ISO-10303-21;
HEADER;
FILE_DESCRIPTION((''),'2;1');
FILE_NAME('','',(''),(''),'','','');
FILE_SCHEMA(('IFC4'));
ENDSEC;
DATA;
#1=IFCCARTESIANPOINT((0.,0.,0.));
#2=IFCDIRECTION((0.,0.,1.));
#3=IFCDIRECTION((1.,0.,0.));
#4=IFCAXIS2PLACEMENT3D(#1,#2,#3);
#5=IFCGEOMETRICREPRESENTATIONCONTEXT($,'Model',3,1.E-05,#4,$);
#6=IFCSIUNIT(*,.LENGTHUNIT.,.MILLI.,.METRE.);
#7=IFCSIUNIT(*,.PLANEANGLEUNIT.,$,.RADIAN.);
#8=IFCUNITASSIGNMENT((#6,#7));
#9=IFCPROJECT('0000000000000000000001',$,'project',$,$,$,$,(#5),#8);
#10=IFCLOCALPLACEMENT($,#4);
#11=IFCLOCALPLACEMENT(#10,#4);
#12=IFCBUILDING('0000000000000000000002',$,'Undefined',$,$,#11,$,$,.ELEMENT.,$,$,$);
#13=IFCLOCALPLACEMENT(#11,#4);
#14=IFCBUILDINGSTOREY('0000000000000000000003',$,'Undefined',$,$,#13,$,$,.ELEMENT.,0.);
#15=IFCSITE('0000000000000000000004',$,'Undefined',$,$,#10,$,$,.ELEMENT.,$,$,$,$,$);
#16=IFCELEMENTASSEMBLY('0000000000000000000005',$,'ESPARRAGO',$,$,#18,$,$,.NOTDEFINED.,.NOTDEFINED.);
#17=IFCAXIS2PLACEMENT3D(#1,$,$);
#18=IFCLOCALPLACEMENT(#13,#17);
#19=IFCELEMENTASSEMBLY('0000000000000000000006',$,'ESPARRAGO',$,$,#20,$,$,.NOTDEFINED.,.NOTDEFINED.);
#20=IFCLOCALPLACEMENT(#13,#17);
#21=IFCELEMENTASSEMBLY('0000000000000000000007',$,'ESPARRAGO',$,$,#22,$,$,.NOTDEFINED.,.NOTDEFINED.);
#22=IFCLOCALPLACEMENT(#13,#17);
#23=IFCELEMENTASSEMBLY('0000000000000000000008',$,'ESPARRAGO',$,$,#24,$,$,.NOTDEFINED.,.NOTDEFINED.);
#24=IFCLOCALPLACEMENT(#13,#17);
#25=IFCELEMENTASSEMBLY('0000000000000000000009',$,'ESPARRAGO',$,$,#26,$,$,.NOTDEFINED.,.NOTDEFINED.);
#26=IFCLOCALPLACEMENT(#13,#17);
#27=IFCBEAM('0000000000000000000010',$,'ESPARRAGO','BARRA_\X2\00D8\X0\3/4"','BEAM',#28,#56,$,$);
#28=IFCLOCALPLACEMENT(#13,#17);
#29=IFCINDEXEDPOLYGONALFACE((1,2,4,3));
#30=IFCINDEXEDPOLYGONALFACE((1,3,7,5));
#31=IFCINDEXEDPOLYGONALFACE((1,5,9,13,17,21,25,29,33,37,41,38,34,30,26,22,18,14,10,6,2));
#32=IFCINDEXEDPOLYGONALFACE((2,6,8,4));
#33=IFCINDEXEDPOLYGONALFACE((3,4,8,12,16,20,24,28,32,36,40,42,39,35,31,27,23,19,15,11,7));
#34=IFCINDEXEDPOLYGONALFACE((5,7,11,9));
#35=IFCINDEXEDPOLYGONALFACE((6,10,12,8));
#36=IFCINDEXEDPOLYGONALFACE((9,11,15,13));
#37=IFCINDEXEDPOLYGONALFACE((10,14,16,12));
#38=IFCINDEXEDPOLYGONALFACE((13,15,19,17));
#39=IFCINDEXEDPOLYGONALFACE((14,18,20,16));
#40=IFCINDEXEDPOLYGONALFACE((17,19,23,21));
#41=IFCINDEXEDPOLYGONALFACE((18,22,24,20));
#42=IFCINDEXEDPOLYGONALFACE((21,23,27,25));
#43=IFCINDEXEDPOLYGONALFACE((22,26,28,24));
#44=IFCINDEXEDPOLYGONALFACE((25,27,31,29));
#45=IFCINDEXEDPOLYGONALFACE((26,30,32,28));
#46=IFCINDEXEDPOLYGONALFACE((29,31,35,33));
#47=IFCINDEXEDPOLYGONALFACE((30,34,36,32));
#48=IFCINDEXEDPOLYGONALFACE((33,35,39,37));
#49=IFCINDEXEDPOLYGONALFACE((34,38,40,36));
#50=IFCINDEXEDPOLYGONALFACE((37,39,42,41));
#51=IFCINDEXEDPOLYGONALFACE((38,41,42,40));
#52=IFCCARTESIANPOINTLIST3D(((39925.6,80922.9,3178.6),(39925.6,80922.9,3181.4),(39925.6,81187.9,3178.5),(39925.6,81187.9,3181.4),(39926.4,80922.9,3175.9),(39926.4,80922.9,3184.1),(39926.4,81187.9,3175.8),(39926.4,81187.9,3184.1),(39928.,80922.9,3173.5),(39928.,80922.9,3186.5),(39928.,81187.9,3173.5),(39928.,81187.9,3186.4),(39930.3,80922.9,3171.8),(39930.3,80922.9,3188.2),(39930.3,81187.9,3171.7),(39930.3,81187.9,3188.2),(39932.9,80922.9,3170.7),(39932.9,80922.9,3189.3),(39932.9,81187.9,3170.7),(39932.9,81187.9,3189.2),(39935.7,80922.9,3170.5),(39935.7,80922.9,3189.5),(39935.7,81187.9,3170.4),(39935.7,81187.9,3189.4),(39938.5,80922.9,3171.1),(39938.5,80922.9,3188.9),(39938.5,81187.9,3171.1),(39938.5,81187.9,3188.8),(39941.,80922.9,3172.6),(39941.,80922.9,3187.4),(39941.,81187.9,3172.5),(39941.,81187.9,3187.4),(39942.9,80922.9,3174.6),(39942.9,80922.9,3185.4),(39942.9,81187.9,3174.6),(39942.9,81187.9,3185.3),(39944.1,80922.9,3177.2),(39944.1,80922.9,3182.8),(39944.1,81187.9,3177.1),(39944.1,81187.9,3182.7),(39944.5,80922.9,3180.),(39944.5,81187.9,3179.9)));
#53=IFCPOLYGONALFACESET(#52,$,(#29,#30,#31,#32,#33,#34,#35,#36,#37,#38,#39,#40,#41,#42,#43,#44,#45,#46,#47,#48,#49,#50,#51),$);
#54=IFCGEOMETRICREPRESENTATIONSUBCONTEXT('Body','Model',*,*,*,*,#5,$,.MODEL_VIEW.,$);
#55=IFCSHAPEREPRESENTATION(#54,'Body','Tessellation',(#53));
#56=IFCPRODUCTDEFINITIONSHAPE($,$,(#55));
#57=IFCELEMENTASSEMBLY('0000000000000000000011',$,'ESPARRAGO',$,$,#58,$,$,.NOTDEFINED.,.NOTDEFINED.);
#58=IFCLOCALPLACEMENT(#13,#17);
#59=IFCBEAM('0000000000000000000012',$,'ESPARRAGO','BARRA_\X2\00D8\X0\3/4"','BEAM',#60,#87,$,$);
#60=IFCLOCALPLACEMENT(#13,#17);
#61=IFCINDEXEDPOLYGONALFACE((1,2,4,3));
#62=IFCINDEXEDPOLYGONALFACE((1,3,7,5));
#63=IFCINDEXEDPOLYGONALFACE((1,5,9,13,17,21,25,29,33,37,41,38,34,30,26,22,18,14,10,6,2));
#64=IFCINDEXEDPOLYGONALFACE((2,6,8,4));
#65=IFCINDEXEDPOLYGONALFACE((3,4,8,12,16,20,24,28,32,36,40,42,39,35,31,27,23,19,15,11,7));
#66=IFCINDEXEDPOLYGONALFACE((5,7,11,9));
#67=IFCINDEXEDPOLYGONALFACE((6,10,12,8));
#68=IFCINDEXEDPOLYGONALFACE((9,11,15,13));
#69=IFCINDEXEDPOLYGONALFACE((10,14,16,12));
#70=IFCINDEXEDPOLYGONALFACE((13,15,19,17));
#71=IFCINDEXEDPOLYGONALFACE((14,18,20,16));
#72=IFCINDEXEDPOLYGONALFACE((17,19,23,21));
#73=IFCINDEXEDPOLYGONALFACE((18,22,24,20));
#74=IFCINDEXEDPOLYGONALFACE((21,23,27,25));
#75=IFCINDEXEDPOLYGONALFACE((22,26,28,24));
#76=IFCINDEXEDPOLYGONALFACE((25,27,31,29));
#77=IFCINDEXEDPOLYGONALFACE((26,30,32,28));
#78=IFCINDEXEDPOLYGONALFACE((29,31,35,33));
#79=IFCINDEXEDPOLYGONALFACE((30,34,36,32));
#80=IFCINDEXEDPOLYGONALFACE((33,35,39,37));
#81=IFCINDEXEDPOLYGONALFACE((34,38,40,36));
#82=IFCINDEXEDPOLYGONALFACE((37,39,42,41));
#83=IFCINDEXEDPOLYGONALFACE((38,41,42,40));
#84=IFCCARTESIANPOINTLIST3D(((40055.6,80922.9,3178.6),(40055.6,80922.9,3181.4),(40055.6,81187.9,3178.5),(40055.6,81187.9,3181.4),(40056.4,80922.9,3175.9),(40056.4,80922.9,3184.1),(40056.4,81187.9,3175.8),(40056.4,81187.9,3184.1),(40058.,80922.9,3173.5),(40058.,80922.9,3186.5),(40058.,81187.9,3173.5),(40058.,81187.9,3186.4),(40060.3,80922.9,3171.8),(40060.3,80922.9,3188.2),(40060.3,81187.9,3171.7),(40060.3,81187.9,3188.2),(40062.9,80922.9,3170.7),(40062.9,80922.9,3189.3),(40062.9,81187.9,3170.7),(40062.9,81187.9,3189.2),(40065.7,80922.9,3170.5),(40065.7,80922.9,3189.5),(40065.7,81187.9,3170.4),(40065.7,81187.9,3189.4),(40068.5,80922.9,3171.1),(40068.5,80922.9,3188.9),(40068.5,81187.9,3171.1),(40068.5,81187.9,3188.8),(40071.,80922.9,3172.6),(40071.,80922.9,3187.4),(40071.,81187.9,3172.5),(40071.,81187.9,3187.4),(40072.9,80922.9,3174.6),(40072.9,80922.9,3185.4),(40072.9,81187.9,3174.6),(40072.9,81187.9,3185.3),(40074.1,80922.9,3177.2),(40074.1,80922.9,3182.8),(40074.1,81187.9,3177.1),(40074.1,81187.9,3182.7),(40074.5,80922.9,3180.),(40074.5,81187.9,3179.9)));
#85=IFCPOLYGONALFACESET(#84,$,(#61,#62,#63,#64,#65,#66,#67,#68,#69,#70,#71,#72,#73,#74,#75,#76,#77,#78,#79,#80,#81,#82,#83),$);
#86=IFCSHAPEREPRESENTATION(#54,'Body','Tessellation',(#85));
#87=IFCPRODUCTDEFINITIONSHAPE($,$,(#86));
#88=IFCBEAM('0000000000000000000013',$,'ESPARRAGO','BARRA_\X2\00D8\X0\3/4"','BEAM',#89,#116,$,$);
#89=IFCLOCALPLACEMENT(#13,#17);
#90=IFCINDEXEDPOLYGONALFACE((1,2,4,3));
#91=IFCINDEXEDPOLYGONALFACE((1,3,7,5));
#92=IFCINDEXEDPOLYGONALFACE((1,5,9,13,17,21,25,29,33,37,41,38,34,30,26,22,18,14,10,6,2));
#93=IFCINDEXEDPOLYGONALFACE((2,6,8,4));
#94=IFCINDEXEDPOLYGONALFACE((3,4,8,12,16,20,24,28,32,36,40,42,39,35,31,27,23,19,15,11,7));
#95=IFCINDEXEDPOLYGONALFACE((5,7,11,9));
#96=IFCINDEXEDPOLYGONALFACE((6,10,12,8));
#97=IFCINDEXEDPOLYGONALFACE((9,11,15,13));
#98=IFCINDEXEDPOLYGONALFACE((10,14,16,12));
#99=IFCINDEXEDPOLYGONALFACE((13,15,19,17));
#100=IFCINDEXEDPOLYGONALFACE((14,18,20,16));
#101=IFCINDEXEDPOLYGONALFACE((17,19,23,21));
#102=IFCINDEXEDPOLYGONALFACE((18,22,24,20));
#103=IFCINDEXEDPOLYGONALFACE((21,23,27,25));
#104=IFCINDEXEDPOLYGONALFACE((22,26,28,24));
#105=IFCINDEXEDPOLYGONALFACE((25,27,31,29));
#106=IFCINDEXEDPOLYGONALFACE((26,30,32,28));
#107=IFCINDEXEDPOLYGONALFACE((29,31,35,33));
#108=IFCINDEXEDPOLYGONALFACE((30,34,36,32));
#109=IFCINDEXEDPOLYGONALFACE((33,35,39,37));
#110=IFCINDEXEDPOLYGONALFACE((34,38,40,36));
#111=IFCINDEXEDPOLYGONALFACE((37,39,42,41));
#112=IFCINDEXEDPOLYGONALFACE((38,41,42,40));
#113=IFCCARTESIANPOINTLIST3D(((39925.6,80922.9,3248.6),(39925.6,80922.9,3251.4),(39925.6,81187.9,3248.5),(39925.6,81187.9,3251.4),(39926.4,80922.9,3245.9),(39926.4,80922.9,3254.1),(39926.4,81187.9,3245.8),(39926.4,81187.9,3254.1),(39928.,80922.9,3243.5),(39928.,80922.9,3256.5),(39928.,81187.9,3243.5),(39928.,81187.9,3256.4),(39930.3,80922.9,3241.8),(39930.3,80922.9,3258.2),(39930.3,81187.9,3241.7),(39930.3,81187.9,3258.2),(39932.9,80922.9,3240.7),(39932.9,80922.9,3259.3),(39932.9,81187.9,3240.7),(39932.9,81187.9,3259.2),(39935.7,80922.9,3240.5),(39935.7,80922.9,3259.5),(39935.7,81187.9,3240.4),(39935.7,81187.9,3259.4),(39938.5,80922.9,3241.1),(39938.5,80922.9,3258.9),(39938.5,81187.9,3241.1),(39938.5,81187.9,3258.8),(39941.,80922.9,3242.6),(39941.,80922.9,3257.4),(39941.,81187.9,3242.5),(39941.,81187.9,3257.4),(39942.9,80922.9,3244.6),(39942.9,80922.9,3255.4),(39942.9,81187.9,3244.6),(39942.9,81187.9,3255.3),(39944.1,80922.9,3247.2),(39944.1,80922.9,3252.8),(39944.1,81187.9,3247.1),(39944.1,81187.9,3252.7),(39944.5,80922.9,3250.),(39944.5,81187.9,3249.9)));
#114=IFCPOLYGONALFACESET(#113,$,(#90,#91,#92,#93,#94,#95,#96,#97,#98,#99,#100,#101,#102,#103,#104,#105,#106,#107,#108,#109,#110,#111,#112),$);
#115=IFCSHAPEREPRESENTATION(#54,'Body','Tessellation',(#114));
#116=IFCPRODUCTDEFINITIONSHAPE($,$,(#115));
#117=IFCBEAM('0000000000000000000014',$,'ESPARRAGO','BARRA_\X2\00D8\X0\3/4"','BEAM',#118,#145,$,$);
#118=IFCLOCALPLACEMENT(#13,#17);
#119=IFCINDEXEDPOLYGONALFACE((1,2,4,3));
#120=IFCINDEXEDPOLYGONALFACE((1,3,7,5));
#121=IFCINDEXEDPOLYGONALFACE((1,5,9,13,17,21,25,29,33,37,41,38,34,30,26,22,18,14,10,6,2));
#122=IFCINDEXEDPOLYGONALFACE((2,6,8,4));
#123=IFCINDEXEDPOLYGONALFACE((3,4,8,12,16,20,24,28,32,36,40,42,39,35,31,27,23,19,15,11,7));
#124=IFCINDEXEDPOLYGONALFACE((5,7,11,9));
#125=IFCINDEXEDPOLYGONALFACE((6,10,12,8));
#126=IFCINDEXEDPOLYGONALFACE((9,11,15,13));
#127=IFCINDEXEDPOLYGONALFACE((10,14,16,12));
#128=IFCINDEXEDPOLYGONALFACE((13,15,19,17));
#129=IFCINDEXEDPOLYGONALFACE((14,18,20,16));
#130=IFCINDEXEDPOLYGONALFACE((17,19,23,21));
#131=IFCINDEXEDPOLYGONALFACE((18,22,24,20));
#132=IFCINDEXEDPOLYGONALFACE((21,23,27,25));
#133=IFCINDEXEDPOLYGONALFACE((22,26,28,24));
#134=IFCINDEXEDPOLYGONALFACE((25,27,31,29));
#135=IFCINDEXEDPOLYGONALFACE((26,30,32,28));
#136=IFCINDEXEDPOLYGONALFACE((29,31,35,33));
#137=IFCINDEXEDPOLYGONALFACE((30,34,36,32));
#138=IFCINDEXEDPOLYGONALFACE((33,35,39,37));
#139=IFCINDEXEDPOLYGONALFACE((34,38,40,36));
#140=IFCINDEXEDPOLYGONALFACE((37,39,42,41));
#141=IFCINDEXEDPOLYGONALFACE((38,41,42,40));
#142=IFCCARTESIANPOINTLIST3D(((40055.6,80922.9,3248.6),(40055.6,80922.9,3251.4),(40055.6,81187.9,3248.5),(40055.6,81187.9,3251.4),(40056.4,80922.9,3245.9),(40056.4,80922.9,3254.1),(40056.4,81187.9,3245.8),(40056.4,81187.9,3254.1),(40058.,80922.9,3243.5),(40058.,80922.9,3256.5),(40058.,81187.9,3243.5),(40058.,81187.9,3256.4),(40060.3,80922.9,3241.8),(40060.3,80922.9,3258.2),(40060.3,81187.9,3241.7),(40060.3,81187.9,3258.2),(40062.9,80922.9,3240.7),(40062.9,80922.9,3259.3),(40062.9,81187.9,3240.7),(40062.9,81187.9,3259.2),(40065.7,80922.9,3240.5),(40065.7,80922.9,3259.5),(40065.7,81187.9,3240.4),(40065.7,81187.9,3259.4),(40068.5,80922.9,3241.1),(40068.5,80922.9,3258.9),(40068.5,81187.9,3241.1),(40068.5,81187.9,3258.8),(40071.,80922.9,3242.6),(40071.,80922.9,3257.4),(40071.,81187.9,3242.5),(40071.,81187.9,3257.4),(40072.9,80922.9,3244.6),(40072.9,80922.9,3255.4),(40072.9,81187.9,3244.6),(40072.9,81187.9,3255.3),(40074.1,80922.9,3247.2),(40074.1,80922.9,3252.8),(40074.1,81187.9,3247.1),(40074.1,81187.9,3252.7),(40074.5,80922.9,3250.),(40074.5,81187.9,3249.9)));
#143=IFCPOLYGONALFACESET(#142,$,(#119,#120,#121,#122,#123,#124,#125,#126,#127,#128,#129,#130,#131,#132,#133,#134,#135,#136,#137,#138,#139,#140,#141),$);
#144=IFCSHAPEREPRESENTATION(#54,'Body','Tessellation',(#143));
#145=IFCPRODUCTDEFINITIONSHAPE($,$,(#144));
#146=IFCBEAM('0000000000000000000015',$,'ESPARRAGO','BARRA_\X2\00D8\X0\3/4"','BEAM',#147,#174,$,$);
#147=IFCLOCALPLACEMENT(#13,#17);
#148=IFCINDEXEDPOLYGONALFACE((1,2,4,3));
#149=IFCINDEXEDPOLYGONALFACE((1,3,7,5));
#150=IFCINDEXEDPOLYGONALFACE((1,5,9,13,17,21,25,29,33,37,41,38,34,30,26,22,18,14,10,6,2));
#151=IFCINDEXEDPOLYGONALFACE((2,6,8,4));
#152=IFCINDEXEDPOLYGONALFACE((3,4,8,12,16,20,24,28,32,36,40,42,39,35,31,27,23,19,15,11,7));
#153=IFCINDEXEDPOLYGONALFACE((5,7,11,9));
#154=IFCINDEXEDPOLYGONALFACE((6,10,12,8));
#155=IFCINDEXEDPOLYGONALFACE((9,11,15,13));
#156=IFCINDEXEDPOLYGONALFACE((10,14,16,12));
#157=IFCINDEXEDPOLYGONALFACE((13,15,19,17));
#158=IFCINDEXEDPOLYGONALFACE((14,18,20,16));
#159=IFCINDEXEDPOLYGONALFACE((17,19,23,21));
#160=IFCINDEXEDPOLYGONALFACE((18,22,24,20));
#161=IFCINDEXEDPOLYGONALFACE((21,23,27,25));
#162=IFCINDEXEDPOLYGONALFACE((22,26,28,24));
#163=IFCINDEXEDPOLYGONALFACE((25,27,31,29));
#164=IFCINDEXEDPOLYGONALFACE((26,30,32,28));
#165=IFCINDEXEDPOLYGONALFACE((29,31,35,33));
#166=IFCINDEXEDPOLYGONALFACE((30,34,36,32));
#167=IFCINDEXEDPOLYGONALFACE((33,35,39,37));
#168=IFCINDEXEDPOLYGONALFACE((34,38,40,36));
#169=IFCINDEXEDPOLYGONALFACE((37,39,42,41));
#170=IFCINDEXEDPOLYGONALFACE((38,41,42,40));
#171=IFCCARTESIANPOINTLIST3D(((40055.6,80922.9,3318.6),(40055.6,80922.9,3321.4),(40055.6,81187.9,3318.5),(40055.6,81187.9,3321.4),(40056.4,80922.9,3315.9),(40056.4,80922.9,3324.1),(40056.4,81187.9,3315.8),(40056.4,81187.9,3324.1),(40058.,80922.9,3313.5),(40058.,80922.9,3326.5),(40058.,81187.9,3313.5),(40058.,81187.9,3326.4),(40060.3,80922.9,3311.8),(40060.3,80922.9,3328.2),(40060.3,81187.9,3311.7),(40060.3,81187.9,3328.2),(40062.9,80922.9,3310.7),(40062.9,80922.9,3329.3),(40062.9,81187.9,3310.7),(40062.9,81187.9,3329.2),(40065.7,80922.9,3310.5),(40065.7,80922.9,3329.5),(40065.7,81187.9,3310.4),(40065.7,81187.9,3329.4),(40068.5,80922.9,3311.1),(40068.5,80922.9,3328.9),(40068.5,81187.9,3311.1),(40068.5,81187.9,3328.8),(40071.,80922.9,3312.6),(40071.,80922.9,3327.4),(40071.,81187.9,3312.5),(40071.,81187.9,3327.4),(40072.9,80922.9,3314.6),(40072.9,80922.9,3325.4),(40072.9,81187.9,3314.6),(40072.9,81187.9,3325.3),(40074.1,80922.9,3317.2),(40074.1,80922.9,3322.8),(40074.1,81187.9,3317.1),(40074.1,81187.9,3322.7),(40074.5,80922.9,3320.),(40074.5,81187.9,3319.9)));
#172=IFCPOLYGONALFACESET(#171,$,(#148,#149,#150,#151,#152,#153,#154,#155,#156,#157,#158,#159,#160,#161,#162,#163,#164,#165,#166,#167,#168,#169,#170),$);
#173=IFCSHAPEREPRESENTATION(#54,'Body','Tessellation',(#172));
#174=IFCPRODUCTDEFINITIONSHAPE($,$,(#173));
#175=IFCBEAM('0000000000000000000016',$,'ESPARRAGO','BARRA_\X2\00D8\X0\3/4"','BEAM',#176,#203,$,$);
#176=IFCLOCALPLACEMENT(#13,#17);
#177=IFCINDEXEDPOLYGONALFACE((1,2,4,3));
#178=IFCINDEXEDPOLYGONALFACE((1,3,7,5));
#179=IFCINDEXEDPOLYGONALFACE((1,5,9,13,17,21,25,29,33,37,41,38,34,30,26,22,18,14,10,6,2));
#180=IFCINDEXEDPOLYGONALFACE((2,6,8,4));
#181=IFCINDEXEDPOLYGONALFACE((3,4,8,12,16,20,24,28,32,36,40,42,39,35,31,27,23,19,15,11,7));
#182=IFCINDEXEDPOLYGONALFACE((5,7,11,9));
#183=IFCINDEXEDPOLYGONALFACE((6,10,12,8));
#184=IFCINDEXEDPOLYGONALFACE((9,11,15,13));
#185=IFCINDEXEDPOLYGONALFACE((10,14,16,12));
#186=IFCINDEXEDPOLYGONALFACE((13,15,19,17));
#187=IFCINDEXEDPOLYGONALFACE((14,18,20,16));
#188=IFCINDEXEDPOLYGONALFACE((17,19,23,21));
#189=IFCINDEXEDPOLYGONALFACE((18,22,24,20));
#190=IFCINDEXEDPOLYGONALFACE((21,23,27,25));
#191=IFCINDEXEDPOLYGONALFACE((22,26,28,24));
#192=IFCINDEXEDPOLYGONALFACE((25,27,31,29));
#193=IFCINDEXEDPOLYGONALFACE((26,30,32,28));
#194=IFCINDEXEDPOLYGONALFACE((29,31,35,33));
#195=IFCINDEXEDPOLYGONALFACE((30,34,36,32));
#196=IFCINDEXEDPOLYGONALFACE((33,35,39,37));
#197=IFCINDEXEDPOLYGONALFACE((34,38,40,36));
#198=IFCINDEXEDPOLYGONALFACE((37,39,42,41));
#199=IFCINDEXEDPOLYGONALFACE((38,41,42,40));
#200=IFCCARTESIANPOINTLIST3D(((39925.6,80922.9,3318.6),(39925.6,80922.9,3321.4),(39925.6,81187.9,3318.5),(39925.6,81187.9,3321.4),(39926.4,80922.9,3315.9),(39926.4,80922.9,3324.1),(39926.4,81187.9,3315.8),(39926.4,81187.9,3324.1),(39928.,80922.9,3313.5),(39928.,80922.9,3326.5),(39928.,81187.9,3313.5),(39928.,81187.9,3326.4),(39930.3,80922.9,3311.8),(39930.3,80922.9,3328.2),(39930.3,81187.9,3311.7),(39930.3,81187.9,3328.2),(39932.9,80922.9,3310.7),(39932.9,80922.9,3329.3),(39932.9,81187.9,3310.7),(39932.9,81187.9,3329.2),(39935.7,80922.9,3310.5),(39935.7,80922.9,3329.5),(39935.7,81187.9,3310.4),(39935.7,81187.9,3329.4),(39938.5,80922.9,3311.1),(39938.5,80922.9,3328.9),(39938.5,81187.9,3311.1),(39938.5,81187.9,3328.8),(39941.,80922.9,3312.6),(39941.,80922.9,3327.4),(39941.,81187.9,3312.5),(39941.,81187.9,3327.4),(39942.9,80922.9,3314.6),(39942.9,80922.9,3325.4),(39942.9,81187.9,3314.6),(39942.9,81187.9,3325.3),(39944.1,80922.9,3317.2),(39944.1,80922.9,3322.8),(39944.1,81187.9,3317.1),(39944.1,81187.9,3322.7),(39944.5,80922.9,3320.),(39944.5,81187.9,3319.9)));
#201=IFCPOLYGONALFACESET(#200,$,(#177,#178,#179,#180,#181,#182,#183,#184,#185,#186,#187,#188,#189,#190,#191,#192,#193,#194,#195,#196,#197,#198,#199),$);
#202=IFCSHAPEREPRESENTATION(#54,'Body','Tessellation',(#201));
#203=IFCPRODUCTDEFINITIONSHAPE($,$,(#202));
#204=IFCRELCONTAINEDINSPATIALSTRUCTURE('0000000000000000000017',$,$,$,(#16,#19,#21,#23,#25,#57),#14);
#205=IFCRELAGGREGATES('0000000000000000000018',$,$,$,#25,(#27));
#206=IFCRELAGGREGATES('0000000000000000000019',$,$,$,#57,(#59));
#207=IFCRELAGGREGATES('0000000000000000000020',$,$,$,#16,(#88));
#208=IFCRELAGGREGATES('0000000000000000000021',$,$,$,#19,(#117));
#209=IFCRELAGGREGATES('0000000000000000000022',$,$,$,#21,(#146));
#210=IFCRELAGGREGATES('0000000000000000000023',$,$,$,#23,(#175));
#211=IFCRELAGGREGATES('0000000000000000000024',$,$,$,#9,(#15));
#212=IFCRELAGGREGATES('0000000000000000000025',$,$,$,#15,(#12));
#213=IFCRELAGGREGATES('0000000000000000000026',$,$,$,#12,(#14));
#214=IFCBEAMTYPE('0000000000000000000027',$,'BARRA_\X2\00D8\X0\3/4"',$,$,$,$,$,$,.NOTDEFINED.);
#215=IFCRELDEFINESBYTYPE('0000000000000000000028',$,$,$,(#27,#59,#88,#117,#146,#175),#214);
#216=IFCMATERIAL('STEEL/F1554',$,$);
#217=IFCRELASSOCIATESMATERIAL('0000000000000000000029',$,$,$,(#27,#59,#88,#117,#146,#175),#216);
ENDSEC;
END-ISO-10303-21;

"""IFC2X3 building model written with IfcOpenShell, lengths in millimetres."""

from ifc_helpers import new_model, si_unit, frame, origin_with_axes, origin_2d_with_axis, place, context, subcontext, project, spatial, circle, extrude, material, type_object, element, aggregate, save


model = new_model("IFC2X3")

# Units and contexts
model_context = context("Model", 3, precision=1e-05, world=origin_with_axes())
body_context = subcontext(model_context, "Body", "Model", "MODEL_VIEW")
ifc_project = project(units=[si_unit("LENGTHUNIT", "METRE", prefix="MILLI"), si_unit("PLANEANGLEUNIT", "RADIAN")], contexts=[model_context])

# Site, building, storey
site_placement = place(None, origin_with_axes())
site = spatial("IfcSite", under=ifc_project, at=site_placement, Name="Undefined", CompositionType="ELEMENT")
building_placement = place(site_placement, origin_with_axes())
building = spatial("IfcBuilding", under=site, at=building_placement, Name="Undefined", CompositionType="ELEMENT")
storey_placement = place(building_placement, origin_with_axes())
storey = spatial("IfcBuildingStorey", under=building, at=storey_placement, Name="Undefined", CompositionType="ELEMENT", Elevation=0.0)

# Element assemblies
assembly_1_placement = place(storey_placement, origin_with_axes())
assembly_1 = element("IfcElementAssembly", 1, at=assembly_1_placement, inside=storey, Name="ESPARRAGO", AssemblyPlace="NOTDEFINED", PredefinedType="NOTDEFINED")
assembly_2_placement = place(storey_placement, origin_with_axes())
assembly_2 = element("IfcElementAssembly", 2, at=assembly_2_placement, inside=storey, Name="ESPARRAGO", AssemblyPlace="NOTDEFINED", PredefinedType="NOTDEFINED")
assembly_3_placement = place(storey_placement, origin_with_axes())
assembly_3 = element("IfcElementAssembly", 3, at=assembly_3_placement, inside=storey, Name="ESPARRAGO", AssemblyPlace="NOTDEFINED", PredefinedType="NOTDEFINED")
assembly_4_placement = place(storey_placement, origin_with_axes())
assembly_4 = element("IfcElementAssembly", 4, at=assembly_4_placement, inside=storey, Name="ESPARRAGO", AssemblyPlace="NOTDEFINED", PredefinedType="NOTDEFINED")

# Element assemblies, beams
assembly_5_placement = place(storey_placement, origin_with_axes())
assembly_5 = element("IfcElementAssembly", 5, at=assembly_5_placement, inside=storey, Name="ESPARRAGO", AssemblyPlace="NOTDEFINED", PredefinedType="NOTDEFINED")
ifc_material_1 = material(Name="STEEL/F1554")
beam_type_1 = type_object("IfcBeamType", Name="BARRA_Ø3/4\"", PredefinedType="NOTDEFINED")
beam_1_placement = place(assembly_5_placement, frame((39935.0, 80922.9, 3180.0), z_axis=(0.0, 0.000238, 1.0), x_axis=(0.000019, 1.0, -0.000238)))
beam_1 = element("IfcBeam", 6, at=beam_1_placement, type_object=beam_type_1, material=ifc_material_1, Name="ESPARRAGO", Description="BARRA_Ø3/4\"", ObjectType="BEAM", context=body_context, shape_type="SweptSolid", body=[
    extrude(circle(Radius=9.5, at=origin_2d_with_axis()), frame((265.0, 0.0, 0.0), z_axis=(-1.0, 0.0, 0.0), x_axis=(0.0, -1.0, 0.0)), (0.0, 0.0, 1.0), 265.0),
])
aggregate(assembly_5, [beam_1])
assembly_6_placement = place(storey_placement, origin_with_axes())
assembly_6 = element("IfcElementAssembly", 7, at=assembly_6_placement, inside=storey, Name="ESPARRAGO", AssemblyPlace="NOTDEFINED", PredefinedType="NOTDEFINED")
beam_2_placement = place(assembly_6_placement, frame((40065.0, 80922.9, 3180.0), z_axis=(0.0, 0.000238, 1.0), x_axis=(0.000019, 1.0, -0.000238)))
beam_2 = element("IfcBeam", 8, at=beam_2_placement, type_object=beam_type_1, material=ifc_material_1, Name="ESPARRAGO", Description="BARRA_Ø3/4\"", ObjectType="BEAM", context=body_context, shape_type="SweptSolid", body=[
    extrude(circle(Radius=9.5, at=origin_2d_with_axis()), frame((265.0, 0.0, 0.0), z_axis=(-1.0, 0.0, 0.0), x_axis=(0.0, -1.0, 0.0)), (0.0, 0.0, 1.0), 265.0),
])
aggregate(assembly_6, [beam_2])

# Beams
beam_3_placement = place(assembly_1_placement, frame((39935.0, 80922.9, 3250.0), z_axis=(0.0, 0.000238, 1.0), x_axis=(0.000019, 1.0, -0.000238)))
beam_3 = element("IfcBeam", 9, at=beam_3_placement, type_object=beam_type_1, material=ifc_material_1, Name="ESPARRAGO", Description="BARRA_Ø3/4\"", ObjectType="BEAM", context=body_context, shape_type="SweptSolid", body=[
    extrude(circle(Radius=9.5, at=origin_2d_with_axis()), frame((265.0, 0.0, 0.0), z_axis=(-1.0, 0.0, 0.0), x_axis=(0.0, -1.0, 0.0)), (0.0, 0.0, 1.0), 265.0),
])
aggregate(assembly_1, [beam_3])
beam_4_placement = place(assembly_2_placement, frame((40065.0, 80922.9, 3250.0), z_axis=(0.0, 0.000238, 1.0), x_axis=(0.000019, 1.0, -0.000238)))
beam_4 = element("IfcBeam", 10, at=beam_4_placement, type_object=beam_type_1, material=ifc_material_1, Name="ESPARRAGO", Description="BARRA_Ø3/4\"", ObjectType="BEAM", context=body_context, shape_type="SweptSolid", body=[
    extrude(circle(Radius=9.5, at=origin_2d_with_axis()), frame((265.0, 0.0, 0.0), z_axis=(-1.0, 0.0, 0.0), x_axis=(0.0, -1.0, 0.0)), (0.0, 0.0, 1.0), 265.0),
])
aggregate(assembly_2, [beam_4])
beam_5_placement = place(assembly_3_placement, frame((40065.0, 80922.9, 3320.0), z_axis=(0.0, 0.000238, 1.0), x_axis=(0.000019, 1.0, -0.000238)))
beam_5 = element("IfcBeam", 11, at=beam_5_placement, type_object=beam_type_1, material=ifc_material_1, Name="ESPARRAGO", Description="BARRA_Ø3/4\"", ObjectType="BEAM", context=body_context, shape_type="SweptSolid", body=[
    extrude(circle(Radius=9.5, at=origin_2d_with_axis()), frame((265.0, 0.0, 0.0), z_axis=(-1.0, 0.0, 0.0), x_axis=(0.0, -1.0, 0.0)), (0.0, 0.0, 1.0), 265.0),
])
aggregate(assembly_3, [beam_5])
beam_6_placement = place(assembly_4_placement, frame((39935.0, 80922.9, 3320.0), z_axis=(0.0, 0.000238, 1.0), x_axis=(0.000019, 1.0, -0.000238)))
beam_6 = element("IfcBeam", 12, at=beam_6_placement, type_object=beam_type_1, material=ifc_material_1, Name="ESPARRAGO", Description="BARRA_Ø3/4\"", ObjectType="BEAM", context=body_context, shape_type="SweptSolid", body=[
    extrude(circle(Radius=9.5, at=origin_2d_with_axis()), frame((265.0, 0.0, 0.0), z_axis=(-1.0, 0.0, 0.0), x_axis=(0.0, -1.0, 0.0)), (0.0, 0.0, 1.0), 265.0),
])
aggregate(assembly_4, [beam_6])

save(model, "model.ifc")
